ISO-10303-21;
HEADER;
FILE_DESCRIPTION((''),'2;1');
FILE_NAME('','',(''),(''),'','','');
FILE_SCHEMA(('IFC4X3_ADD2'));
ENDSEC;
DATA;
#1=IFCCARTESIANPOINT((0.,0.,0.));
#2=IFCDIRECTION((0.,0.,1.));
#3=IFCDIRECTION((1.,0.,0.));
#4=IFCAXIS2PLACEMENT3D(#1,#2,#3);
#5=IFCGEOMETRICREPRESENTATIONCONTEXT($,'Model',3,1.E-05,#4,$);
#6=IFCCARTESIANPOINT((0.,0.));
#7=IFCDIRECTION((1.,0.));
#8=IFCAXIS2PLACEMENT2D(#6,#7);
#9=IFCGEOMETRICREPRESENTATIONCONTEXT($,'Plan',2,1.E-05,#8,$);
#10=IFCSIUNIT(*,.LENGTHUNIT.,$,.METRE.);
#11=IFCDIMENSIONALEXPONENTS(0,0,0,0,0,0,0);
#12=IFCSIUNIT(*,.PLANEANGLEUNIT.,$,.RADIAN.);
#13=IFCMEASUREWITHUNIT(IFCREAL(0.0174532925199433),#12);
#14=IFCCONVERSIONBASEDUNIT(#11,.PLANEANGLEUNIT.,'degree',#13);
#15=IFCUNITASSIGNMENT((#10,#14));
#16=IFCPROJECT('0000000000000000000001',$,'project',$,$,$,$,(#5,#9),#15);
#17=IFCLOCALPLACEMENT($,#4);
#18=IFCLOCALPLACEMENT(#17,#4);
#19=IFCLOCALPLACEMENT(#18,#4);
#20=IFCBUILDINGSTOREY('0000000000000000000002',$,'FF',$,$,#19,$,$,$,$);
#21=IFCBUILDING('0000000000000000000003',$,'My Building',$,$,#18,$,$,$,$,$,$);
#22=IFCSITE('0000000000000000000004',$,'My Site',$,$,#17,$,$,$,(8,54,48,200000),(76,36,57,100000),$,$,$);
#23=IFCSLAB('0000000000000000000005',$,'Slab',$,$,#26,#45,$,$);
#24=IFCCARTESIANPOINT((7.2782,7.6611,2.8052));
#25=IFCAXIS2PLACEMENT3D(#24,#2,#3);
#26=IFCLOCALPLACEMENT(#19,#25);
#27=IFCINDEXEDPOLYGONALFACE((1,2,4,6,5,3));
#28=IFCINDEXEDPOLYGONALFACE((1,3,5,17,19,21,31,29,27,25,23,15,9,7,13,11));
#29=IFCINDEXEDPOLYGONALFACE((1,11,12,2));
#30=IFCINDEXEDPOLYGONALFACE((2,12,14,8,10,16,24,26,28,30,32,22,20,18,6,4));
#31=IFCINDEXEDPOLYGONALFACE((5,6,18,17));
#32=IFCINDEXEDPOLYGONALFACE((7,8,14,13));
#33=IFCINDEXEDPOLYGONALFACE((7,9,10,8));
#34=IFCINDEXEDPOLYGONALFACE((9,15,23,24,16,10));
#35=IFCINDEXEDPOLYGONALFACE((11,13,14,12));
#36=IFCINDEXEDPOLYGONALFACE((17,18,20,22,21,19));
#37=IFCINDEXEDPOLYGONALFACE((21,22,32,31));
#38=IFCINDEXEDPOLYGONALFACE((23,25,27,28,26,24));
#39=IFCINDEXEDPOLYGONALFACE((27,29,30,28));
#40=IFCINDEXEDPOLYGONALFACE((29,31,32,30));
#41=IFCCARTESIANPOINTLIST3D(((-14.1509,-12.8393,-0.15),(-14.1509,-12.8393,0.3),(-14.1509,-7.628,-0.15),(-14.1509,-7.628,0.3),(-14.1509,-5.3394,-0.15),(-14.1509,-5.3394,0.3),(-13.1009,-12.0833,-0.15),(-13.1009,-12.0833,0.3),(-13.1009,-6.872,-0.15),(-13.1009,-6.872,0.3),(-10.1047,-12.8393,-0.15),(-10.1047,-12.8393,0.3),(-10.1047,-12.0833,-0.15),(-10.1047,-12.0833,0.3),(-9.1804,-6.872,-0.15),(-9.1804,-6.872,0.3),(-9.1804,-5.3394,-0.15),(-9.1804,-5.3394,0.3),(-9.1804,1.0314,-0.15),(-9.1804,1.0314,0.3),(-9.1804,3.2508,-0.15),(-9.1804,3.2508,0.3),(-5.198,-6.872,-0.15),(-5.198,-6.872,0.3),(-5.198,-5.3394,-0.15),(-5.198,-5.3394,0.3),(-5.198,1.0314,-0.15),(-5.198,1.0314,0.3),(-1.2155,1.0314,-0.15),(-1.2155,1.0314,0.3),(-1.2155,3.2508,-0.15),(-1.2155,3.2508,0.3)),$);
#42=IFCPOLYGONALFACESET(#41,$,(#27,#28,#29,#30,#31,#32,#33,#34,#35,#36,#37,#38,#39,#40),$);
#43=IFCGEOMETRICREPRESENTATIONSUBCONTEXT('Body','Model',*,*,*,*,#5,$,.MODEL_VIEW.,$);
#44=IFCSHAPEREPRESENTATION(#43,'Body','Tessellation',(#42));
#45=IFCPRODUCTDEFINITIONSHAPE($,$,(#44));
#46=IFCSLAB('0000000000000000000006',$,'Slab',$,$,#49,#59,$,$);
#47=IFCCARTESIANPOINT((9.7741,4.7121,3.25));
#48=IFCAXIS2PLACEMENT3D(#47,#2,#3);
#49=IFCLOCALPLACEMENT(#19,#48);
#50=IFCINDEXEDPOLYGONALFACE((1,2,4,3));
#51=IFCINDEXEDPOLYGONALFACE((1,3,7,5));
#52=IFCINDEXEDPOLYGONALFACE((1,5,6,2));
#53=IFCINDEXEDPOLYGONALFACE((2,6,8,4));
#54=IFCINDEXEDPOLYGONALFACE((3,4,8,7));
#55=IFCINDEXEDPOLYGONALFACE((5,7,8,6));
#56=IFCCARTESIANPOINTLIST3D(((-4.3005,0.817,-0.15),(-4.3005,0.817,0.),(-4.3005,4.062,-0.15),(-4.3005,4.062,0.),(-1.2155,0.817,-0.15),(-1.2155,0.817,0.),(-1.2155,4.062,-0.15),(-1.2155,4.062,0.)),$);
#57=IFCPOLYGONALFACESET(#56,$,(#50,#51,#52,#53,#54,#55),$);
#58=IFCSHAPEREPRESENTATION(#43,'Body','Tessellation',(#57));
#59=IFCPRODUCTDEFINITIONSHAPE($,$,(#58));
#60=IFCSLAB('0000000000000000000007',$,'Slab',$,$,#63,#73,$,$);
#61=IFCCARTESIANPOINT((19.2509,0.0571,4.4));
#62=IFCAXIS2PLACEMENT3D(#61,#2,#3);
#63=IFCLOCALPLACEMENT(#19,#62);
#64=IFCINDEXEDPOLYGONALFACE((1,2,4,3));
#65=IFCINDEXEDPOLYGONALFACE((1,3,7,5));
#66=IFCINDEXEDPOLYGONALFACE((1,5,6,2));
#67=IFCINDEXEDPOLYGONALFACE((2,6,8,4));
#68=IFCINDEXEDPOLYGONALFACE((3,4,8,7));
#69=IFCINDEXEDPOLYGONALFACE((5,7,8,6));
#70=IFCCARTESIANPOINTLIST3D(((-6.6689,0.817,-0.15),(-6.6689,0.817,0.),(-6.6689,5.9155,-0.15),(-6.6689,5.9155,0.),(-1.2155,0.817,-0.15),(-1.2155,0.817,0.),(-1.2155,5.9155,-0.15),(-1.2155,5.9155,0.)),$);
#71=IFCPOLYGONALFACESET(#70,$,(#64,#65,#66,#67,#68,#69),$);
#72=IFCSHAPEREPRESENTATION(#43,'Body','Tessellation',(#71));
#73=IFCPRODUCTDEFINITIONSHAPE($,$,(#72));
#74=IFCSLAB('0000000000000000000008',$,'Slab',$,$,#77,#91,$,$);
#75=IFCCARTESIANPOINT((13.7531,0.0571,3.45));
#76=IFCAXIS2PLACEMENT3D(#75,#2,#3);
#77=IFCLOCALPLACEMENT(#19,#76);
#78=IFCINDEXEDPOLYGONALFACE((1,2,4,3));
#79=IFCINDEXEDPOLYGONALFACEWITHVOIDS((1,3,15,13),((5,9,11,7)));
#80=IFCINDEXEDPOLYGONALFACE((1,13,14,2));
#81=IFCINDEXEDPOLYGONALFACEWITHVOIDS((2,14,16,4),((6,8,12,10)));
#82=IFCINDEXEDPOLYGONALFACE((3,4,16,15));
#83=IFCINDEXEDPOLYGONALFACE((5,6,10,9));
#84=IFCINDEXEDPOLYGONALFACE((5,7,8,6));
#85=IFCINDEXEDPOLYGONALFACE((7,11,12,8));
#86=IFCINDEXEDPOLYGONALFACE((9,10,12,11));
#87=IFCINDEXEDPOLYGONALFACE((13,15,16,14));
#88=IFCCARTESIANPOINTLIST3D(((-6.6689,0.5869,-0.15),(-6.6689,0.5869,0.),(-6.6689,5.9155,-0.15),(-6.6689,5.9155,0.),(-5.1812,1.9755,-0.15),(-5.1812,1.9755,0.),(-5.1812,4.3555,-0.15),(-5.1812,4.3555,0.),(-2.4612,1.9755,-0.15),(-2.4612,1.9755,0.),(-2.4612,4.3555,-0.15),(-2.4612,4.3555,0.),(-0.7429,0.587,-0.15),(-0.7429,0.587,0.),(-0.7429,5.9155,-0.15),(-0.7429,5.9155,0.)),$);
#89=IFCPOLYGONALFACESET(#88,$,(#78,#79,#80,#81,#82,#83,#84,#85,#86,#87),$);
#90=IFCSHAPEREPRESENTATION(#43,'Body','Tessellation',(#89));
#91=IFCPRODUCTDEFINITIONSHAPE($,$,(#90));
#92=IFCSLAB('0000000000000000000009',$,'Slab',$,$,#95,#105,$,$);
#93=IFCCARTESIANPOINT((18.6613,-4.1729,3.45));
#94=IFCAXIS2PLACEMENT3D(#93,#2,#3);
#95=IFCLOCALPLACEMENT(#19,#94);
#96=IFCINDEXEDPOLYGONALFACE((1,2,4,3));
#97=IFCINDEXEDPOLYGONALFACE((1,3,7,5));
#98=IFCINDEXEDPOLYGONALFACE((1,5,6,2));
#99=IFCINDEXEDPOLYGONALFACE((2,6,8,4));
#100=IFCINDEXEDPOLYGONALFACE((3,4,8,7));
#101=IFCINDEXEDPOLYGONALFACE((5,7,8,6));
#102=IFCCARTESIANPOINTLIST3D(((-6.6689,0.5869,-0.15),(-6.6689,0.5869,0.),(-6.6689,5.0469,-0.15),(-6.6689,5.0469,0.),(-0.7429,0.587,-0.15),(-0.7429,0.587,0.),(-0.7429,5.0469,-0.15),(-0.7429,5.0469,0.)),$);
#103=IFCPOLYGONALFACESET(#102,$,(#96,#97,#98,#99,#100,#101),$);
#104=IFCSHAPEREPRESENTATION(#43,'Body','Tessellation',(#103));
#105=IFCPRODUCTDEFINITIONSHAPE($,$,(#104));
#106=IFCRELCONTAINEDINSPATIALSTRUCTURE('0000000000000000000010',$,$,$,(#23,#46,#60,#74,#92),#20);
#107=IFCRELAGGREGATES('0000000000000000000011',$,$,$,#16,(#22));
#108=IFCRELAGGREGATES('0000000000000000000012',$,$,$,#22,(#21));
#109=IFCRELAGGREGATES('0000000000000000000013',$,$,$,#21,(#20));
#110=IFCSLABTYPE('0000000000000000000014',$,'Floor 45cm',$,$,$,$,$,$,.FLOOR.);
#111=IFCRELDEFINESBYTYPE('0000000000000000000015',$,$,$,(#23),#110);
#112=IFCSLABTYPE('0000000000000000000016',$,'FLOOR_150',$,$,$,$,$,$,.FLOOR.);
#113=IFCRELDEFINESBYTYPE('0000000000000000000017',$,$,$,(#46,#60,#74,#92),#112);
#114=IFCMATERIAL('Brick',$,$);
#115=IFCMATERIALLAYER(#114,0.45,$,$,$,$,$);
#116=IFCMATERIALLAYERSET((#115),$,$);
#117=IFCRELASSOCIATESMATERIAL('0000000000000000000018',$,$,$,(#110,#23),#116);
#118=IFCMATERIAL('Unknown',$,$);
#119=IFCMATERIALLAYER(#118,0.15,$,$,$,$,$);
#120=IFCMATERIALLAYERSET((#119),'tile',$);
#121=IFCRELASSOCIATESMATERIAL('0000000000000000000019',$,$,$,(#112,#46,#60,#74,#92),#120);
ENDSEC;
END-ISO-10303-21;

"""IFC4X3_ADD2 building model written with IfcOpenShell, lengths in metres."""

from ifc_helpers import new_model, entity, si_unit, converted_unit, frame, origin_with_axes, origin_2d_with_axis, place, context, subcontext, project, spatial, indexed_curve, outline, extrude, material, layer, layer_set, layer_usage, type_object, element, save


model = new_model("IFC4X3_ADD2")

# Units and contexts
model_context = context("Model", 3, precision=1e-05, world=origin_with_axes())
plan_context = context("Plan", 2, precision=1e-05, world=origin_2d_with_axis())
body_context = subcontext(model_context, "Body", "Model", "MODEL_VIEW")
ifc_project = project(units=[si_unit("LENGTHUNIT", "METRE"), converted_unit("PLANEANGLEUNIT", "degree", entity("IfcReal", 0.0174532925199433), si_unit("PLANEANGLEUNIT", "RADIAN"), dimensions=[0, 0, 0, 0, 0, 0, 0])], contexts=[model_context, plan_context])

# Site, building, storey
site_placement = place(None, origin_with_axes())
site = spatial("IfcSite", under=ifc_project, at=site_placement, Name="My Site", RefLatitude=(8, 54, 48, 200000), RefLongitude=(76, 36, 57, 100000))
building_placement = place(site_placement, origin_with_axes())
building = spatial("IfcBuilding", under=site, at=building_placement, Name="My Building")
storey_placement = place(building_placement, origin_with_axes())
storey = spatial("IfcBuildingStorey", under=building, at=storey_placement, Name="FF")

# Slabs
ifc_material_1 = material(Name="Brick")
ifc_layer_1 = layer(ifc_material_1, 0.45)
ifc_layer_set_1 = layer_set([ifc_layer_1])
ifc_layer_usage_1 = layer_usage(ifc_layer_set_1, "AXIS3", "POSITIVE", -0.15)
slab_type_1 = type_object("IfcSlabType", Name="Floor 45cm", PredefinedType="FLOOR", material=ifc_layer_set_1)
slab_1_placement = place(storey_placement, frame((7.2782, 7.6611, 2.8052), z_axis=(0.0, 0.0, 1.0), x_axis=(1.0, 0.0, 0.0)))
element("IfcSlab", 1, at=slab_1_placement, inside=storey, type_object=slab_type_1, material=ifc_layer_usage_1, Name="Slab", context=body_context, shape_type="SweptSolid", body=[
    extrude(outline(indexed_curve([(-9.1804, -5.3394), (-14.1509, -5.3394), (-14.1509, -7.628), (-14.1509, -12.8393), (-10.1047, -12.8393), (-10.1047, -12.0833), (-13.1009, -12.0833), (-13.1009, -6.872), (-9.1804, -6.872), (-5.198, -6.872), (-5.198, -5.3394), (-5.198, 1.0314), (-1.2155, 1.0314), (-1.2155, 3.2508), (-9.1804, 3.2508), (-9.1804, 1.0314), (-9.1804, -5.3394)])), frame((0.0, 0.0, -0.15), z_axis=(0.0, 0.0, 1.0), x_axis=(1.0, 0.0, 0.0)), (0.0, 0.0, 1.0), 0.45),
])
ifc_material_2 = material(Name="Unknown")
ifc_layer_2 = layer(ifc_material_2, 0.15)
ifc_layer_set_2 = layer_set([ifc_layer_2], Name="tile")
ifc_layer_usage_2 = layer_usage(ifc_layer_set_2, "AXIS3", "POSITIVE", -0.15)
slab_type_2 = type_object("IfcSlabType", Name="FLOOR_150", PredefinedType="FLOOR", material=ifc_layer_set_2)
slab_2_placement = place(storey_placement, frame((9.7741, 4.7121, 3.25), z_axis=(0.0, 0.0, 1.0), x_axis=(1.0, 0.0, 0.0)))
element("IfcSlab", 2, at=slab_2_placement, inside=storey, type_object=slab_type_2, material=ifc_layer_usage_2, Name="Slab", context=body_context, shape_type="SweptSolid", body=[
    extrude(outline(indexed_curve([(-1.2155, 0.817), (-1.2155, 4.062), (-4.3005, 4.062), (-4.3005, 0.817), (-1.2155, 0.817)])), frame((0.0, 0.0, -0.15), z_axis=(0.0, 0.0, 1.0), x_axis=(1.0, 0.0, 0.0)), (0.0, 0.0, 1.0), 0.15),
])
ifc_layer_usage_3 = layer_usage(ifc_layer_set_2, "AXIS3", "POSITIVE", -0.15)
slab_3_placement = place(storey_placement, frame((19.2509, 0.0571, 4.4), z_axis=(0.0, 0.0, 1.0), x_axis=(1.0, 0.0, 0.0)))
element("IfcSlab", 3, at=slab_3_placement, inside=storey, type_object=slab_type_2, material=ifc_layer_usage_3, Name="Slab", context=body_context, shape_type="SweptSolid", body=[
    extrude(outline(indexed_curve([(-6.6689, 0.817), (-6.6689, 5.9155), (-1.2155, 5.9155), (-1.2155, 0.817), (-6.6689, 0.817)])), frame((0.0, 0.0, -0.15), z_axis=(0.0, 0.0, 1.0), x_axis=(1.0, 0.0, 0.0)), (0.0, 0.0, 1.0), 0.15),
])
ifc_layer_usage_4 = layer_usage(ifc_layer_set_2, "AXIS3", "POSITIVE", -0.15)
slab_4_placement = place(storey_placement, frame((13.7531, 0.0571, 3.45), z_axis=(0.0, 0.0, 1.0), x_axis=(1.0, 0.0, 0.0)))
element("IfcSlab", 4, at=slab_4_placement, inside=storey, type_object=slab_type_2, material=ifc_layer_usage_4, Name="Slab", context=body_context, shape_type="SweptSolid", body=[
    extrude(outline(indexed_curve([(-6.6689, 0.5869), (-6.6689, 5.9155), (-0.7429, 5.9155), (-0.7429, 0.587), (-6.6689, 0.5869)]), holes=[indexed_curve([(-5.1812, 1.9755), (-5.1812, 4.3555), (-2.4612, 4.3555), (-2.4612, 1.9755), (-5.1812, 1.9755)])]), frame((0.0, 0.0, -0.15), z_axis=(0.0, 0.0, 1.0), x_axis=(1.0, 0.0, 0.0)), (0.0, 0.0, 1.0), 0.15),
])
ifc_layer_usage_5 = layer_usage(ifc_layer_set_2, "AXIS3", "POSITIVE", -0.15)
slab_5_placement = place(storey_placement, frame((18.6613, -4.1729, 3.45), z_axis=(0.0, 0.0, 1.0), x_axis=(1.0, 0.0, 0.0)))
element("IfcSlab", 5, at=slab_5_placement, inside=storey, type_object=slab_type_2, material=ifc_layer_usage_5, Name="Slab", context=body_context, shape_type="SweptSolid", body=[
    extrude(outline(indexed_curve([(-6.6689, 0.5869), (-6.6689, 5.0469), (-0.7429, 5.0469), (-0.7429, 0.587), (-6.6689, 0.5869)])), frame((0.0, 0.0, -0.15), z_axis=(0.0, 0.0, 1.0), x_axis=(1.0, 0.0, 0.0)), (0.0, 0.0, 1.0), 0.15),
])

save(model, "model.ifc")
